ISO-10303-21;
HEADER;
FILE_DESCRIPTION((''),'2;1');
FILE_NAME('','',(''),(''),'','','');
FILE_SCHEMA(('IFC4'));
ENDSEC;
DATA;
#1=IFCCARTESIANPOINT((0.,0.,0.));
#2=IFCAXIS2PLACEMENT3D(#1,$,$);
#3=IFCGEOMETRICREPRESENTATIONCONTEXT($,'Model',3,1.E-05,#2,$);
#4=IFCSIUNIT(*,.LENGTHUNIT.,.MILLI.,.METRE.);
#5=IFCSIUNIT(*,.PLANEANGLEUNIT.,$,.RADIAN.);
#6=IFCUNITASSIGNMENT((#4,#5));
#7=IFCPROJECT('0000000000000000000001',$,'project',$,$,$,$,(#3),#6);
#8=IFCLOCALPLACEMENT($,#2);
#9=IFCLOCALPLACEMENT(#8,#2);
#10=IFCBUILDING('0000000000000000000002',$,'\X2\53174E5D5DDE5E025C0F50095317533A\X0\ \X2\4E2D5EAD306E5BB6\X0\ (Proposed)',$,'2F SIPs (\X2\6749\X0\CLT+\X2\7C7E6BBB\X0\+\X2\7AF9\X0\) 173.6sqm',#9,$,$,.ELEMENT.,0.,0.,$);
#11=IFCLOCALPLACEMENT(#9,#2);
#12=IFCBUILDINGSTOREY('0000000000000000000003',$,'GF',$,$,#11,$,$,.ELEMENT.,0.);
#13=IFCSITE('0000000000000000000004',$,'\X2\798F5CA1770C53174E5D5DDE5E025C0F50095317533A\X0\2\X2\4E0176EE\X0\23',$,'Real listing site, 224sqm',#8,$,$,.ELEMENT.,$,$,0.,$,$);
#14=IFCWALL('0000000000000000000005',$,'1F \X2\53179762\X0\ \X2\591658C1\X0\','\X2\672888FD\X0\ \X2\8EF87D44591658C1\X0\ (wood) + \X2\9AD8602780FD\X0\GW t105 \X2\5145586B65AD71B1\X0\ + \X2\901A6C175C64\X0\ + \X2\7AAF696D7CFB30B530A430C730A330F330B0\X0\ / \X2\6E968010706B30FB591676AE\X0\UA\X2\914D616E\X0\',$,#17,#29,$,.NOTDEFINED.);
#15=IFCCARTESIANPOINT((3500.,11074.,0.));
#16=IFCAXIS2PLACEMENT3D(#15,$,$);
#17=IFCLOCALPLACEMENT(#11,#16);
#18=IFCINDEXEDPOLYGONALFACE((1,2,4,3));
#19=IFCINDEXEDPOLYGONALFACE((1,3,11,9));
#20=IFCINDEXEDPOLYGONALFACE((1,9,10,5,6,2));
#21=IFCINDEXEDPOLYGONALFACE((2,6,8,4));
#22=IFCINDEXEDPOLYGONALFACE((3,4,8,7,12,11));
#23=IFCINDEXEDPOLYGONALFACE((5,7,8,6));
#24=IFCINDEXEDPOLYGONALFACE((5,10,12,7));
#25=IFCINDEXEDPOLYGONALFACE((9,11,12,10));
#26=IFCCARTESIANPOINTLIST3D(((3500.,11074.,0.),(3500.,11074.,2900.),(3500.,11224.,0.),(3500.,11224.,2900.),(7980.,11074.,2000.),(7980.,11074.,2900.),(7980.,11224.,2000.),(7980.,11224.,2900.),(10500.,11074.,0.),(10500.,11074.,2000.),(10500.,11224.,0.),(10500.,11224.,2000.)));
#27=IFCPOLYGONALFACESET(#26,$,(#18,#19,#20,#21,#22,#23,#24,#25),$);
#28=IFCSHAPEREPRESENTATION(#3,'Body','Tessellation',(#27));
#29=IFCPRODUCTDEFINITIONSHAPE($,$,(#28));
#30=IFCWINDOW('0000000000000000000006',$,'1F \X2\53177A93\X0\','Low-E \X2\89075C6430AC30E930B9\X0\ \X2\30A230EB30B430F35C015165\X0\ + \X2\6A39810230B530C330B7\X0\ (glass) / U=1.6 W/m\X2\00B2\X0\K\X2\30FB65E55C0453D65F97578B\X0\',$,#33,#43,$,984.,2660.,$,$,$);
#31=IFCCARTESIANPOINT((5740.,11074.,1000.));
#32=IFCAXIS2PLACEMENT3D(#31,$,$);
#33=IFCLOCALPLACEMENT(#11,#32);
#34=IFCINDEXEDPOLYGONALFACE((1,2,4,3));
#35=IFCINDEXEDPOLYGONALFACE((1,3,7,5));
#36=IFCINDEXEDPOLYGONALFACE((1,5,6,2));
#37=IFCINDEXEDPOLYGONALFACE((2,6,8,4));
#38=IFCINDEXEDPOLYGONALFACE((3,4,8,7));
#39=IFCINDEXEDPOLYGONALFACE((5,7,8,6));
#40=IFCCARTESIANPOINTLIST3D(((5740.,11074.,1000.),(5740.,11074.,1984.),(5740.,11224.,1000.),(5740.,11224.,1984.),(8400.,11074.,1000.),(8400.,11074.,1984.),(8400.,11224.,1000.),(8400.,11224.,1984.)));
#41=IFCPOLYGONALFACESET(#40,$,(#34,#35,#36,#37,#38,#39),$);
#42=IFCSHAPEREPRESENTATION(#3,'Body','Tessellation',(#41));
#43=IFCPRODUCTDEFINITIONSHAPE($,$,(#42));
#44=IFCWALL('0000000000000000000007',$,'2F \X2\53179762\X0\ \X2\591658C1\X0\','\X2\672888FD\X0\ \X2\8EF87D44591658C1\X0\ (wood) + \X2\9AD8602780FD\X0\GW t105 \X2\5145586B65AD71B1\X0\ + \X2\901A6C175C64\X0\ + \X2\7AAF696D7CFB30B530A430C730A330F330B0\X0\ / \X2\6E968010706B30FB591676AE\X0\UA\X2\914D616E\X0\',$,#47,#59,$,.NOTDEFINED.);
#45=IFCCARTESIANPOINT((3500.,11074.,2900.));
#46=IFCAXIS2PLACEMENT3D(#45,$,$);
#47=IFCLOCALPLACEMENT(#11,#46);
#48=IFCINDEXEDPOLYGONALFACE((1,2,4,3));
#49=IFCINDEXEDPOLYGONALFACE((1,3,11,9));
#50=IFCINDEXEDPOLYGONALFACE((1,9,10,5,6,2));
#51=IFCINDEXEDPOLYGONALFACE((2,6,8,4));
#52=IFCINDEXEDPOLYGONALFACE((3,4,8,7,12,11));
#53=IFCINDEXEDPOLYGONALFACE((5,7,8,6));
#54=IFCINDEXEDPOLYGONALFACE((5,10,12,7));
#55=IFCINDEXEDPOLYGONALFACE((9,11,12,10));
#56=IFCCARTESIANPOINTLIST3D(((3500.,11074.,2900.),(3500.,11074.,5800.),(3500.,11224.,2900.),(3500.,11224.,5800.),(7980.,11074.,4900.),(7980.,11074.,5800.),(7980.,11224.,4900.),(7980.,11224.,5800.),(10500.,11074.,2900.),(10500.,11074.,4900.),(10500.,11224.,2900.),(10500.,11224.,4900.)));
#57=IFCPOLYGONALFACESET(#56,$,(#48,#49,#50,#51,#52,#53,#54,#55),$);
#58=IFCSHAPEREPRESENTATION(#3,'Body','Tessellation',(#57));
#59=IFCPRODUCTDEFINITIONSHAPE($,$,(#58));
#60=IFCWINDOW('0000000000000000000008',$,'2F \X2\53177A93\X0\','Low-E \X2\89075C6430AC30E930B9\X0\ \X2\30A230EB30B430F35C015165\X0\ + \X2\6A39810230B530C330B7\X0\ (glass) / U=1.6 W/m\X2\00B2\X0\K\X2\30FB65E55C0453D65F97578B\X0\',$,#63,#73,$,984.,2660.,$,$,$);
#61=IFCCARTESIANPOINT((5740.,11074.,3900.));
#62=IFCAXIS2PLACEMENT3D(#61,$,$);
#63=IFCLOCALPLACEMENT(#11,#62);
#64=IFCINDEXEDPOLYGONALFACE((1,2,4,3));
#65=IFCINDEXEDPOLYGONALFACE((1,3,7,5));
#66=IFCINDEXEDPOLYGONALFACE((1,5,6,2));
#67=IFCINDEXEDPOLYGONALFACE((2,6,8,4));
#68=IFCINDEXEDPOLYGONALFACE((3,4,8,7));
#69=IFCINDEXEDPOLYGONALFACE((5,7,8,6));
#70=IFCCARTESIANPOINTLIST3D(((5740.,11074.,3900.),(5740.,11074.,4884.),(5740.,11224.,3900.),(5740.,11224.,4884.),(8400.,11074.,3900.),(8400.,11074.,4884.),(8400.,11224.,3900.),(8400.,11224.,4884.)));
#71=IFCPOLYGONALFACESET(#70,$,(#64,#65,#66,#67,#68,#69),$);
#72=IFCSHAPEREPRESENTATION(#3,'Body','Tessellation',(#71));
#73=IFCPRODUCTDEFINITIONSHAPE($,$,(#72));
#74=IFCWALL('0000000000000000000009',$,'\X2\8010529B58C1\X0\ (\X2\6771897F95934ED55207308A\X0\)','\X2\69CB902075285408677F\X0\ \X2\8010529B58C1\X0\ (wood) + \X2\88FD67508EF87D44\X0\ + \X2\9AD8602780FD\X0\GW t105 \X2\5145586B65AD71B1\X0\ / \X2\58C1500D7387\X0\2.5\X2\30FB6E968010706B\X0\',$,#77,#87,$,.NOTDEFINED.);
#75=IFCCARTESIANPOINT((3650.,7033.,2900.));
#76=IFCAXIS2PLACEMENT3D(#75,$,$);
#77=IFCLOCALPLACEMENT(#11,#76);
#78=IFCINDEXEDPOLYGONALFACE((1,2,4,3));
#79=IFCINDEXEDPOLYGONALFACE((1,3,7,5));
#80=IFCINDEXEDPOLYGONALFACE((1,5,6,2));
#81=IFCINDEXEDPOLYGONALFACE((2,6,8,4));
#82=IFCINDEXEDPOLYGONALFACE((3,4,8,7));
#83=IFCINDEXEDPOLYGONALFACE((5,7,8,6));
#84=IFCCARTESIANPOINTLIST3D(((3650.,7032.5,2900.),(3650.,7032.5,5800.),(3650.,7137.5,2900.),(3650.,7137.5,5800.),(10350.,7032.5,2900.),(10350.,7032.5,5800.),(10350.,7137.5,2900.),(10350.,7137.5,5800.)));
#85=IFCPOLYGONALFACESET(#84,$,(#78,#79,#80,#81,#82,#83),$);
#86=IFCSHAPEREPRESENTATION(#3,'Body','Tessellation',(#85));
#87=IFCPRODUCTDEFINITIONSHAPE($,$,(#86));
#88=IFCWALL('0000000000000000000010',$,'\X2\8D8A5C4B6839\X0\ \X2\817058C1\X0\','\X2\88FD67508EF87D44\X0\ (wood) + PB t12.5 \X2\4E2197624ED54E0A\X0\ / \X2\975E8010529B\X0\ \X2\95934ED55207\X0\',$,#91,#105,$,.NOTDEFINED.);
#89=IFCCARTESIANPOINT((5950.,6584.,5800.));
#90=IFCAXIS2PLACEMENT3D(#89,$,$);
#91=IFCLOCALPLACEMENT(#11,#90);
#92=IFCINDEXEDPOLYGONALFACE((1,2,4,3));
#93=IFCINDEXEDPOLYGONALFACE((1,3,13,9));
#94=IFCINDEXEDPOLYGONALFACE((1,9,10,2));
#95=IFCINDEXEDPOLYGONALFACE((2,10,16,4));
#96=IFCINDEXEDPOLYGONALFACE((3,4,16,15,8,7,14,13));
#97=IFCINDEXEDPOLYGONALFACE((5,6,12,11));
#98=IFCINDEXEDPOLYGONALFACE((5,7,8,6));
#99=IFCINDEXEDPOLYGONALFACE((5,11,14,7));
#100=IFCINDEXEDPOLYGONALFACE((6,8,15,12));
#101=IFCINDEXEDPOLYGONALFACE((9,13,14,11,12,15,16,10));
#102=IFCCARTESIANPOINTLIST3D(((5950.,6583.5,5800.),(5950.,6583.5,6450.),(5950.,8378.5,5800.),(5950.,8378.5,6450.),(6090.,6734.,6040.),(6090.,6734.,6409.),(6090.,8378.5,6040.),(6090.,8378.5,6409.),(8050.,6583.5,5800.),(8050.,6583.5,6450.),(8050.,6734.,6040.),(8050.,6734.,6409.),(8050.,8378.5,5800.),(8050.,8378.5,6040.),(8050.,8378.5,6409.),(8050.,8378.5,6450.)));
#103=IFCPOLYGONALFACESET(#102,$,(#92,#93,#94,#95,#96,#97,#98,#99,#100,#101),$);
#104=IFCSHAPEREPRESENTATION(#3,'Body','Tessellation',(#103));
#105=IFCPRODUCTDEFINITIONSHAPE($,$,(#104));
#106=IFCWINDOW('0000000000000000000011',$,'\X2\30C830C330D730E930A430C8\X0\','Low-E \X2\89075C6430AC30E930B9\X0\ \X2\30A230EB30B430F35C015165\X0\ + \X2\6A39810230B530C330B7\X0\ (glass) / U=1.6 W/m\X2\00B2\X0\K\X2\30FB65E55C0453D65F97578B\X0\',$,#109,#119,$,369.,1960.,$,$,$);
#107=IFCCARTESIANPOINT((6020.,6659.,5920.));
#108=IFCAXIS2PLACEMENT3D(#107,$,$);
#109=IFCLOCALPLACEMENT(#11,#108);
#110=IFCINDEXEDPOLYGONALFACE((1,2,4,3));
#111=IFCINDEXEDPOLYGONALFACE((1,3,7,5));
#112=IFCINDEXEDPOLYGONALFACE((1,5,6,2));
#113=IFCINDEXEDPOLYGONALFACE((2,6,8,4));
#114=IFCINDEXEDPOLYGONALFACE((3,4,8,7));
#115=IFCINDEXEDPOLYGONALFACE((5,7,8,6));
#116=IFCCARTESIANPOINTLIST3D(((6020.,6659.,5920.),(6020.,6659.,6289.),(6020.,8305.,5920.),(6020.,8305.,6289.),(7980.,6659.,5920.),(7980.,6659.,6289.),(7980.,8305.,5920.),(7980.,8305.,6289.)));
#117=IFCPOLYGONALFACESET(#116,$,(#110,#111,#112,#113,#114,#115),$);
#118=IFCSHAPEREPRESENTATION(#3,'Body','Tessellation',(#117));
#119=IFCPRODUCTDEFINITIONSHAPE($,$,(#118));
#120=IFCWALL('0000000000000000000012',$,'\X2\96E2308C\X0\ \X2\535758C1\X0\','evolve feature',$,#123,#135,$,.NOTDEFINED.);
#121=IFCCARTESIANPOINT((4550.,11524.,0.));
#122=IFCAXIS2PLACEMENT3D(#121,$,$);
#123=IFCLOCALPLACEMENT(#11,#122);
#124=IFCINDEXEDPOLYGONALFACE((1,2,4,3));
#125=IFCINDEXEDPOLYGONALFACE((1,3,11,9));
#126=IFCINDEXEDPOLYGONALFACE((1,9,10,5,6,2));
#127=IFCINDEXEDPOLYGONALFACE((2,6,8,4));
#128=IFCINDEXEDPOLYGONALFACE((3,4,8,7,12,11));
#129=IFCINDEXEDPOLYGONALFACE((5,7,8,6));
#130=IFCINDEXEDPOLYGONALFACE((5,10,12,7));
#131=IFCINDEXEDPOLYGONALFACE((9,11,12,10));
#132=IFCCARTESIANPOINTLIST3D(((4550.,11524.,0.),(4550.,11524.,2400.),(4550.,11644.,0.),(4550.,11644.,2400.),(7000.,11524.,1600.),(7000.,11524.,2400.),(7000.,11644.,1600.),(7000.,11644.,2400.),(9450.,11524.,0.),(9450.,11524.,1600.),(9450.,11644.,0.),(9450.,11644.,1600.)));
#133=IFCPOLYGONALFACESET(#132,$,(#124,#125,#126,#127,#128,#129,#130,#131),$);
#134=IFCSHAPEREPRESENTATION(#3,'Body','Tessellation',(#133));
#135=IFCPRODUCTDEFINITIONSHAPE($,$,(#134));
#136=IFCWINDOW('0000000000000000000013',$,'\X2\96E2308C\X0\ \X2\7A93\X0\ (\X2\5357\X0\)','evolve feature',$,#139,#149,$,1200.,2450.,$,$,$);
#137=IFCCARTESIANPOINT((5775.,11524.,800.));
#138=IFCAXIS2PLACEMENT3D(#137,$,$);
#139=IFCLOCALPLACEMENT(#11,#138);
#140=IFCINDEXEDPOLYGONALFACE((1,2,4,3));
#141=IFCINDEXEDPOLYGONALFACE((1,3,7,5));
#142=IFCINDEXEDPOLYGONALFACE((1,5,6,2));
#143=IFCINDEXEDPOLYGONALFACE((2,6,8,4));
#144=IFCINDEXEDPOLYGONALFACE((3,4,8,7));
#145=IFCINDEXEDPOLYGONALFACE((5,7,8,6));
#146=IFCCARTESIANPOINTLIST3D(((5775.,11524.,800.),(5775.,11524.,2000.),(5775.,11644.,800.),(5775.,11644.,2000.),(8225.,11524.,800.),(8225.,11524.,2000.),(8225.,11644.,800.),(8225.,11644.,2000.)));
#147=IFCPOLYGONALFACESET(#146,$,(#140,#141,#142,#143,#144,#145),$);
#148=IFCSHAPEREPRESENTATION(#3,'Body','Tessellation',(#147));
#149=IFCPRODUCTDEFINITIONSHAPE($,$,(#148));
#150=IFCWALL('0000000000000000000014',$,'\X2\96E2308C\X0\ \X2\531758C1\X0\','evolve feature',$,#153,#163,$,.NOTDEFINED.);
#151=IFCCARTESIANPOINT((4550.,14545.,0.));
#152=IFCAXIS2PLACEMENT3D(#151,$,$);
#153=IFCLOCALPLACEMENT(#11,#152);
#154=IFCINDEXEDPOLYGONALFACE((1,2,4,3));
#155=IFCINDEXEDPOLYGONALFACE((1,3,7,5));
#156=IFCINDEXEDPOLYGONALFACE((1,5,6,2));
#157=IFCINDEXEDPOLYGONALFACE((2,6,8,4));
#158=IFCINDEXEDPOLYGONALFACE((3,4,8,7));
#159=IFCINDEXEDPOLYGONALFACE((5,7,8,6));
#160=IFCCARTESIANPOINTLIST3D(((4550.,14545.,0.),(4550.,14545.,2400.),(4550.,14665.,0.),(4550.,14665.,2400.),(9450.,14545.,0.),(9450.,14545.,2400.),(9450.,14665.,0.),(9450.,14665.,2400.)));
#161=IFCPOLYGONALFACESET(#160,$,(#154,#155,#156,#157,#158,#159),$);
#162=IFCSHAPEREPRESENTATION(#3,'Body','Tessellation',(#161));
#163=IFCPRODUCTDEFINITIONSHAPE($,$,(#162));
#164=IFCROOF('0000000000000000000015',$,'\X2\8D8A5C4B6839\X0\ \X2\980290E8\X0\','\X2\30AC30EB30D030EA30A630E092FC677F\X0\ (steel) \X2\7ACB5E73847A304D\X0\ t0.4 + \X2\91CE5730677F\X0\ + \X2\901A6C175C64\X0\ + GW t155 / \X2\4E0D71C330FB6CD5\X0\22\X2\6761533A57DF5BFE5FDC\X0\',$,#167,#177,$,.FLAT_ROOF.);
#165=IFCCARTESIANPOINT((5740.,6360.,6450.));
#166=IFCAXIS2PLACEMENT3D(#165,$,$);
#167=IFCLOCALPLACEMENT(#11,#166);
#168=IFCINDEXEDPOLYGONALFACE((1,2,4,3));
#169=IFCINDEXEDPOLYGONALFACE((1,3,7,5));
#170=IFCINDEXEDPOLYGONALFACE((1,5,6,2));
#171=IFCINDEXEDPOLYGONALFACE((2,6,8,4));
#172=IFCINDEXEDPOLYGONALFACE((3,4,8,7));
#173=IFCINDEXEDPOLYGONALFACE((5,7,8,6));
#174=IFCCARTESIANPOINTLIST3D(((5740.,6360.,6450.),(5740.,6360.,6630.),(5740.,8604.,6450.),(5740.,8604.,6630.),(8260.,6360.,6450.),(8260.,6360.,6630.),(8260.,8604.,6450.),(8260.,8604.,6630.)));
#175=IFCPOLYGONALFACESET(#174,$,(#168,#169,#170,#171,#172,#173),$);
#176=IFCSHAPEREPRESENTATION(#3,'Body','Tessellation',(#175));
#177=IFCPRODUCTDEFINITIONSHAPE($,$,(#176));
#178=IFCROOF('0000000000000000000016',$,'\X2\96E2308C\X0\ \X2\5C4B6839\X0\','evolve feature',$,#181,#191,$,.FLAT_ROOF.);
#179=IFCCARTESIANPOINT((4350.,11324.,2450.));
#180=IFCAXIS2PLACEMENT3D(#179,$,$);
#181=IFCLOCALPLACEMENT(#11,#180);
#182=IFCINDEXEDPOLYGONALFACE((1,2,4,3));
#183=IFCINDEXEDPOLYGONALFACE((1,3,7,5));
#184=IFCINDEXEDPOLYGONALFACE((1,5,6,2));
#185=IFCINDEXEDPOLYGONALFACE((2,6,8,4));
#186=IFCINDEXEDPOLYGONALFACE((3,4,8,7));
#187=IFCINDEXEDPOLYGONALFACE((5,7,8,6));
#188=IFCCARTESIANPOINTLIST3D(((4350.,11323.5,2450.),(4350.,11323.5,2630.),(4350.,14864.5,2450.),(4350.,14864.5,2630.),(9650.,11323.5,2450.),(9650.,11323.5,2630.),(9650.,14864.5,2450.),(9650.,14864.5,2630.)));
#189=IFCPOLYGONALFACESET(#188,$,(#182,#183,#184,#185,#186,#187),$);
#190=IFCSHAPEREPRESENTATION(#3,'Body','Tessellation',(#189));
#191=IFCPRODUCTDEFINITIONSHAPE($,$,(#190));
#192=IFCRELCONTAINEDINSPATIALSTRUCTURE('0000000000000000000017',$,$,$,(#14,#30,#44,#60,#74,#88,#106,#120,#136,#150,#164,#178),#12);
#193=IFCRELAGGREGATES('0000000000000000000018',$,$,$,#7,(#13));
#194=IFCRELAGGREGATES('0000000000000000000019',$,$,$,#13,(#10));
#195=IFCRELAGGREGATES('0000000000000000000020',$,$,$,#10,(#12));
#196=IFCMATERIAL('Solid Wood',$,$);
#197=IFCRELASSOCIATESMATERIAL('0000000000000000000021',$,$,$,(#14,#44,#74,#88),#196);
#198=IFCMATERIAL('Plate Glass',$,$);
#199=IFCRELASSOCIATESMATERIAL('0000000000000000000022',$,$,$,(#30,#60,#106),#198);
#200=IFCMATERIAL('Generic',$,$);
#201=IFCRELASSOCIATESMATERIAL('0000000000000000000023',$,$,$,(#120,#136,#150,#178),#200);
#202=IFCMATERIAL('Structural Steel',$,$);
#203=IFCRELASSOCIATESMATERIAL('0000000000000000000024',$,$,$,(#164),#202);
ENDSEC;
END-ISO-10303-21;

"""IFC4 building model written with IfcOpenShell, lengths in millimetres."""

from ifc_helpers import new_model, si_unit, frame, frame_2d, origin, place, context, project, spatial, rectangle, extrude, material, element, fill, save


model = new_model("IFC4")

# Units and contexts
model_context = context("Model", 3, precision=1e-05, world=origin())
ifc_project = project(units=[si_unit("LENGTHUNIT", "METRE", prefix="MILLI"), si_unit("PLANEANGLEUNIT", "RADIAN")], contexts=[model_context])

# Site, building, storey
site_placement = place(None, origin())
site = spatial("IfcSite", under=ifc_project, at=site_placement, Name="福岡県北九州市小倉北区2丁目23", ObjectType="Real listing site, 224sqm", CompositionType="ELEMENT", RefElevation=0.0)
building_placement = place(site_placement, origin())
building = spatial("IfcBuilding", under=site, at=building_placement, Name="北九州市小倉北区 中庭の家 (Proposed)", ObjectType="2F SIPs (杉CLT+籾殻+竹) 173.6sqm", CompositionType="ELEMENT", ElevationOfRefHeight=0.0, ElevationOfTerrain=0.0)
storey_placement = place(building_placement, origin())
storey = spatial("IfcBuildingStorey", under=building, at=storey_placement, Name="GF", CompositionType="ELEMENT", Elevation=0.0)

# Shared definitions
ifc_material_1 = material(Name="Generic")

# Wall, opening, window
ifc_material_2 = material(Name="Solid Wood")
wall_1_placement = place(storey_placement, frame((3500.0, 11074.0, 0.0)))
wall_1 = element("IfcWall", 1, at=wall_1_placement, inside=storey, material=ifc_material_2, Name="1F 北面 外壁", Description="木製 軸組外壁 (wood) + 高性能GW t105 充填断熱 + 通気層 + 窯業系サイディング / 準耐火・外皮UA配慮", PredefinedType="NOTDEFINED", context=model_context, shape_type="SweptSolid", body=[
    extrude(rectangle(XDim=7000.0, YDim=150.0, at=frame_2d((3500.0, 75.0))), frame((3500.0, 11074.0, 0.0)), (0.0, 0.0, 1.0), 2900.0),
])
opening_1_placement = place(storey_placement, frame((5740.0, 11074.0, 1000.0)))
opening_1 = element("IfcOpeningElement", 2, at=opening_1_placement, cuts=wall_1, PredefinedType="NOTDEFINED", context=model_context, shape_type="SweptSolid", body=[
    extrude(rectangle(XDim=2660.0, YDim=150.0, at=frame_2d((1330.0, 75.0))), frame((5740.0, 11074.0, 1000.0)), (0.0, 0.0, 1.0), 984.0),
])
ifc_material_3 = material(Name="Plate Glass")
window_1_placement = place(storey_placement, frame((5740.0, 11074.0, 1000.0)))
window_1 = element("IfcWindow", 3, at=window_1_placement, inside=storey, material=ifc_material_3, Name="1F 北窓", Description="Low-E 複層ガラス アルゴン封入 + 樹脂サッシ (glass) / U=1.6 W/m²K・日射取得型", OverallHeight=984.0, OverallWidth=2660.0, context=model_context, shape_type="SweptSolid", body=[
    extrude(rectangle(XDim=2660.0, YDim=150.0, at=frame_2d((1330.0, 75.0))), frame((5740.0, 11074.0, 1000.0)), (0.0, 0.0, 1.0), 984.0),
])
fill(opening_1, window_1)

# Wall, opening, window
wall_2_placement = place(storey_placement, frame((3500.0, 11074.0, 2900.0)))
wall_2 = element("IfcWall", 4, at=wall_2_placement, inside=storey, material=ifc_material_2, Name="2F 北面 外壁", Description="木製 軸組外壁 (wood) + 高性能GW t105 充填断熱 + 通気層 + 窯業系サイディング / 準耐火・外皮UA配慮", PredefinedType="NOTDEFINED", context=model_context, shape_type="SweptSolid", body=[
    extrude(rectangle(XDim=7000.0, YDim=150.0, at=frame_2d((3500.0, 75.0))), frame((3500.0, 11074.0, 2900.0)), (0.0, 0.0, 1.0), 2900.0),
])
opening_2_placement = place(storey_placement, frame((5740.0, 11074.0, 3900.0)))
opening_2 = element("IfcOpeningElement", 5, at=opening_2_placement, cuts=wall_2, PredefinedType="NOTDEFINED", context=model_context, shape_type="SweptSolid", body=[
    extrude(rectangle(XDim=2660.0, YDim=150.0, at=frame_2d((1330.0, 75.0))), frame((5740.0, 11074.0, 3900.0)), (0.0, 0.0, 1.0), 984.0),
])
window_2_placement = place(storey_placement, frame((5740.0, 11074.0, 3900.0)))
window_2 = element("IfcWindow", 6, at=window_2_placement, inside=storey, material=ifc_material_3, Name="2F 北窓", Description="Low-E 複層ガラス アルゴン封入 + 樹脂サッシ (glass) / U=1.6 W/m²K・日射取得型", OverallHeight=984.0, OverallWidth=2660.0, context=model_context, shape_type="SweptSolid", body=[
    extrude(rectangle(XDim=2660.0, YDim=150.0, at=frame_2d((1330.0, 75.0))), frame((5740.0, 11074.0, 3900.0)), (0.0, 0.0, 1.0), 984.0),
])
fill(opening_2, window_2)

# Wall
wall_3_placement = place(storey_placement, frame((3650.0, 7033.0, 2900.0)))
element("IfcWall", 7, at=wall_3_placement, inside=storey, material=ifc_material_2, Name="耐力壁 (東西間仕切り)", Description="構造用合板 耐力壁 (wood) + 製材軸組 + 高性能GW t105 充填断熱 / 壁倍率2.5・準耐火", PredefinedType="NOTDEFINED", context=model_context, shape_type="SweptSolid", body=[
    extrude(rectangle(XDim=6700.0, YDim=105.0, at=frame_2d((3350.0, 52.0))), frame((3650.0, 7033.0, 2900.0)), (0.0, 0.0, 1.0), 2900.0),
])

# Walls, openings, windows
wall_4_placement = place(storey_placement, frame((5950.0, 6584.0, 5800.0)))
wall_4 = element("IfcWall", 8, at=wall_4_placement, inside=storey, material=ifc_material_2, Name="越屋根 腰壁", Description="製材軸組 (wood) + PB t12.5 両面仕上 / 非耐力 間仕切", PredefinedType="NOTDEFINED", context=model_context, shape_type="SweptSolid", body=[
    extrude(rectangle(XDim=2100.0, YDim=1795.0, at=frame_2d((1050.0, 897.0))), frame((5950.0, 6584.0, 5800.0)), (0.0, 0.0, 1.0), 650.0),
])
opening_3_placement = place(storey_placement, frame((6020.0, 6659.0, 5920.0)))
opening_3 = element("IfcOpeningElement", 9, at=opening_3_placement, cuts=wall_4, PredefinedType="NOTDEFINED", context=model_context, shape_type="SweptSolid", body=[
    extrude(rectangle(XDim=1960.0, YDim=1646.0, at=frame_2d((980.0, 823.0))), frame((6020.0, 6659.0, 5920.0)), (0.0, 0.0, 1.0), 369.0),
])
window_3_placement = place(storey_placement, frame((6020.0, 6659.0, 5920.0)))
window_3 = element("IfcWindow", 10, at=window_3_placement, inside=storey, material=ifc_material_3, Name="トップライト", Description="Low-E 複層ガラス アルゴン封入 + 樹脂サッシ (glass) / U=1.6 W/m²K・日射取得型", OverallHeight=369.0, OverallWidth=1960.0, context=model_context, shape_type="SweptSolid", body=[
    extrude(rectangle(XDim=1960.0, YDim=1646.0, at=frame_2d((980.0, 823.0))), frame((6020.0, 6659.0, 5920.0)), (0.0, 0.0, 1.0), 369.0),
])
fill(opening_3, window_3)
wall_5_placement = place(storey_placement, frame((4550.0, 11524.0, 0.0)))
wall_5 = element("IfcWall", 11, at=wall_5_placement, inside=storey, material=ifc_material_1, Name="離れ 南壁", Description="evolve feature", PredefinedType="NOTDEFINED", context=model_context, shape_type="SweptSolid", body=[
    extrude(rectangle(XDim=4900.0, YDim=120.0, at=frame_2d((2450.0, 60.0))), frame((4550.0, 11524.0, 0.0)), (0.0, 0.0, 1.0), 2400.0),
])
opening_4_placement = place(storey_placement, frame((5775.0, 11524.0, 800.0)))
opening_4 = element("IfcOpeningElement", 12, at=opening_4_placement, cuts=wall_5, PredefinedType="NOTDEFINED", context=model_context, shape_type="SweptSolid", body=[
    extrude(rectangle(XDim=2450.0, YDim=120.0, at=frame_2d((1225.0, 60.0))), frame((5775.0, 11524.0, 800.0)), (0.0, 0.0, 1.0), 1200.0),
])
window_4_placement = place(storey_placement, frame((5775.0, 11524.0, 800.0)))
window_4 = element("IfcWindow", 13, at=window_4_placement, inside=storey, material=ifc_material_1, Name="離れ 窓 (南)", Description="evolve feature", OverallHeight=1200.0, OverallWidth=2450.0, context=model_context, shape_type="SweptSolid", body=[
    extrude(rectangle(XDim=2450.0, YDim=120.0, at=frame_2d((1225.0, 60.0))), frame((5775.0, 11524.0, 800.0)), (0.0, 0.0, 1.0), 1200.0),
])
fill(opening_4, window_4)

# Wall
wall_6_placement = place(storey_placement, frame((4550.0, 14545.0, 0.0)))
element("IfcWall", 14, at=wall_6_placement, inside=storey, material=ifc_material_1, Name="離れ 北壁", Description="evolve feature", PredefinedType="NOTDEFINED", context=model_context, shape_type="SweptSolid", body=[
    extrude(rectangle(XDim=4900.0, YDim=120.0, at=frame_2d((2450.0, 60.0))), frame((4550.0, 14545.0, 0.0)), (0.0, 0.0, 1.0), 2400.0),
])

# Roofs
ifc_material_4 = material(Name="Structural Steel")
roof_1_placement = place(storey_placement, frame((5740.0, 6360.0, 6450.0)))
element("IfcRoof", 15, at=roof_1_placement, inside=storey, material=ifc_material_4, Name="越屋根 頂部", Description="ガルバリウム鋼板 (steel) 立平葺き t0.4 + 野地板 + 通気層 + GW t155 / 不燃・法22条区域対応", PredefinedType="FLAT_ROOF", context=model_context, shape_type="SweptSolid", body=[
    extrude(rectangle(XDim=2520.0, YDim=2244.0, at=frame_2d((1260.0, 1122.0))), frame((5740.0, 6360.0, 6450.0)), (0.0, 0.0, 1.0), 180.0),
])
roof_2_placement = place(storey_placement, frame((4350.0, 11324.0, 2450.0)))
element("IfcRoof", 16, at=roof_2_placement, inside=storey, material=ifc_material_1, Name="離れ 屋根", Description="evolve feature", PredefinedType="FLAT_ROOF", context=model_context, shape_type="SweptSolid", body=[
    extrude(rectangle(XDim=5300.0, YDim=3541.0, at=frame_2d((2650.0, 1770.0))), frame((4350.0, 11324.0, 2450.0)), (0.0, 0.0, 1.0), 180.0),
])

save(model, "model.ifc")
